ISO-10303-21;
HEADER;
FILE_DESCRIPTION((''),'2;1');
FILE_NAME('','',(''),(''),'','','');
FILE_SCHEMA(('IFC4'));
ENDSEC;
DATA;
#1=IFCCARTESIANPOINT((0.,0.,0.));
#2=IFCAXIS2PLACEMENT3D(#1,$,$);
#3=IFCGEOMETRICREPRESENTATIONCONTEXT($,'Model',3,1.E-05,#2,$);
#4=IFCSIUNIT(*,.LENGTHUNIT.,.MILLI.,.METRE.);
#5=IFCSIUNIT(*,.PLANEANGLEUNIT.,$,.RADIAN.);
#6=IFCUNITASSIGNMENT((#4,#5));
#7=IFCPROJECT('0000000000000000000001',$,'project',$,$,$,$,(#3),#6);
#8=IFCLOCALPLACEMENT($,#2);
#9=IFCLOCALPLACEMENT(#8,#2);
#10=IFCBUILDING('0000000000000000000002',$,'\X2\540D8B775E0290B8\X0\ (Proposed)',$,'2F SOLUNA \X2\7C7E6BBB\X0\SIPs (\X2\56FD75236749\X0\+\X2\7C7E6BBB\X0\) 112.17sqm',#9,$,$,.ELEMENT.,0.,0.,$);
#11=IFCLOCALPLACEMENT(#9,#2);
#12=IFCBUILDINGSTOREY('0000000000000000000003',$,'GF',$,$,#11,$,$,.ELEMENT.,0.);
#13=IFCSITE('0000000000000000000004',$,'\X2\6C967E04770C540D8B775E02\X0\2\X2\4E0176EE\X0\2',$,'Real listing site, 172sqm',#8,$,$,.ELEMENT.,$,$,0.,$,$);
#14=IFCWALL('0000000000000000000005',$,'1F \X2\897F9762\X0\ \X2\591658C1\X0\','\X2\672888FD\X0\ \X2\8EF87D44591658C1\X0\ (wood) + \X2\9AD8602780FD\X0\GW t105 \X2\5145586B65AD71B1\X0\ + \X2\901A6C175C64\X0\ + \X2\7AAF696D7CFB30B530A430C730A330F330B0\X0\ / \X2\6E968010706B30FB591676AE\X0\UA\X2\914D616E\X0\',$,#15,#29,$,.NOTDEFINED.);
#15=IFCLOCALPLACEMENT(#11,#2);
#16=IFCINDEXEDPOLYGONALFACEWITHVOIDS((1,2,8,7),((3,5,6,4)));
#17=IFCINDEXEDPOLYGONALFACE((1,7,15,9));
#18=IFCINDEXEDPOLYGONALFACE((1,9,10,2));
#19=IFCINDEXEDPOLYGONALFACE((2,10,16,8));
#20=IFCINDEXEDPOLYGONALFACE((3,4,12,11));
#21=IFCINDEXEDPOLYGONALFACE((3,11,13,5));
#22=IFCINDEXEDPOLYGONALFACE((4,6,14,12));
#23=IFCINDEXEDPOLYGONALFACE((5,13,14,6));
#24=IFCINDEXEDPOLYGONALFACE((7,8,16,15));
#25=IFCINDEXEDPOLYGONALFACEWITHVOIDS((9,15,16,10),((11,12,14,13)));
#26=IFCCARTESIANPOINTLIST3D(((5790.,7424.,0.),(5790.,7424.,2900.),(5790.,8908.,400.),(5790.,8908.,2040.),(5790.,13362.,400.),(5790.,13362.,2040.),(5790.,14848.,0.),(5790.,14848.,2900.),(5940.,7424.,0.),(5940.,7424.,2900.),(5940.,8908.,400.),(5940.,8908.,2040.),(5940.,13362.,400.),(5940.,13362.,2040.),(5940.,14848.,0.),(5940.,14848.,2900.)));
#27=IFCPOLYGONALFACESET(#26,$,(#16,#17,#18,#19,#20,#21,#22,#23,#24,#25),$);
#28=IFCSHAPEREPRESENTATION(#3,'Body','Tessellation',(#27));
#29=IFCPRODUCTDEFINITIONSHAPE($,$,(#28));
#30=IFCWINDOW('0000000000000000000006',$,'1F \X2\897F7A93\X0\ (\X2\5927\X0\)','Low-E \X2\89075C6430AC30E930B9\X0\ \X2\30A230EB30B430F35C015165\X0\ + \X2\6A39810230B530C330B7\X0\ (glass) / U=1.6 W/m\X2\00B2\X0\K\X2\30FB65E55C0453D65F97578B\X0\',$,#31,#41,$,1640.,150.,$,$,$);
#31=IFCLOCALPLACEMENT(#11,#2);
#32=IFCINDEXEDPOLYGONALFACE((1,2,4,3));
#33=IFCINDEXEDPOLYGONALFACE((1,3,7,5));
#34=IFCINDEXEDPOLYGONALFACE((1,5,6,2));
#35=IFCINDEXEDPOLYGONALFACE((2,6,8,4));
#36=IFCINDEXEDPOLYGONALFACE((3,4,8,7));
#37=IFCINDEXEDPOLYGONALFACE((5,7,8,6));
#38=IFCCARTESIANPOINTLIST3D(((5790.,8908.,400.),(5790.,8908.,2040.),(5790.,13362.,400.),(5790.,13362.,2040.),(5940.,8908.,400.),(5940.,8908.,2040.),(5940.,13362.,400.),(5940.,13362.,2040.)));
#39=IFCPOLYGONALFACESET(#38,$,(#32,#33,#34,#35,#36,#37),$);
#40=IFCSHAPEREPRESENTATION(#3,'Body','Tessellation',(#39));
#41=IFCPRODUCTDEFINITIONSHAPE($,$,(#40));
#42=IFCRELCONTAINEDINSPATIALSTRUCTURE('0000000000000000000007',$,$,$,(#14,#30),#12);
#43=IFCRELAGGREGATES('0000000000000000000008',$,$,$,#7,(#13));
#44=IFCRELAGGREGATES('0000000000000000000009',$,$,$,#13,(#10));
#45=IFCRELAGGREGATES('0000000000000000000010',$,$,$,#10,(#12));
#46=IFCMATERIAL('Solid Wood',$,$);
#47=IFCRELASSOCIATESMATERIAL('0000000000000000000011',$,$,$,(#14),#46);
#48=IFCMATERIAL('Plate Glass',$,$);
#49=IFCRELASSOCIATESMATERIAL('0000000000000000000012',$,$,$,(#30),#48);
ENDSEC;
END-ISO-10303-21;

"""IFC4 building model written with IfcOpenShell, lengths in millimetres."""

from ifc_helpers import new_model, si_unit, frame, frame_2d, origin, place, context, project, spatial, rectangle, extrude, material, element, fill, save


model = new_model("IFC4")

# Units and contexts
model_context = context("Model", 3, precision=1e-05, world=origin())
ifc_project = project(units=[si_unit("LENGTHUNIT", "METRE", prefix="MILLI"), si_unit("PLANEANGLEUNIT", "RADIAN")], contexts=[model_context])

# Site, building, storey
site_placement = place(None, origin())
site = spatial("IfcSite", under=ifc_project, at=site_placement, Name="沖縄県名護市2丁目2", ObjectType="Real listing site, 172sqm", CompositionType="ELEMENT", RefElevation=0.0)
building_placement = place(site_placement, origin())
building = spatial("IfcBuilding", under=site, at=building_placement, Name="名護市邸 (Proposed)", ObjectType="2F SOLUNA 籾殻SIPs (国産杉+籾殻) 112.17sqm", CompositionType="ELEMENT", ElevationOfRefHeight=0.0, ElevationOfTerrain=0.0)
storey_placement = place(building_placement, origin())
storey = spatial("IfcBuildingStorey", under=building, at=storey_placement, Name="GF", CompositionType="ELEMENT", Elevation=0.0)

# Shared definitions
ifc_material_1 = material(Name="Solid Wood")

# Shared definitions
ifc_material_2 = material(Name="Plate Glass")

# Wall, opening, window
wall_1_placement = place(storey_placement, frame((2895.0, 3712.0, 0.0)))
wall_1 = element("IfcWall", 1, at=wall_1_placement, inside=storey, material=ifc_material_1, Name="1F 西面 外壁", Description="木製 軸組外壁 (wood) + 高性能GW t105 充填断熱 + 通気層 + 窯業系サイディング / 準耐火・外皮UA配慮", PredefinedType="NOTDEFINED", context=model_context, shape_type="SweptSolid", body=[
    extrude(rectangle(XDim=150.0, YDim=7424.0, at=frame_2d((75.0, 3712.0))), frame((2895.0, 3712.0, 0.0)), (0.0, 0.0, 1.0), 2900.0),
])
opening_1_placement = place(storey_placement, frame((2895.0, 4454.0, 200.0)))
opening_1 = element("IfcOpeningElement", 2, at=opening_1_placement, cuts=wall_1, PredefinedType="NOTDEFINED", context=model_context, shape_type="SweptSolid", body=[
    extrude(rectangle(XDim=150.0, YDim=4454.0, at=frame_2d((75.0, 2227.0))), frame((2895.0, 4454.0, 200.0)), (0.0, 0.0, 1.0), 1640.0),
])
window_1_placement = place(storey_placement, frame((2895.0, 4454.0, 200.0)))
window_1 = element("IfcWindow", 3, at=window_1_placement, inside=storey, material=ifc_material_2, Name="1F 西窓 (大)", Description="Low-E 複層ガラス アルゴン封入 + 樹脂サッシ (glass) / U=1.6 W/m²K・日射取得型", OverallHeight=1640.0, OverallWidth=150.0, context=model_context, shape_type="SweptSolid", body=[
    extrude(rectangle(XDim=150.0, YDim=4454.0, at=frame_2d((75.0, 2227.0))), frame((2895.0, 4454.0, 200.0)), (0.0, 0.0, 1.0), 1640.0),
])
fill(opening_1, window_1)

save(model, "model.ifc")
